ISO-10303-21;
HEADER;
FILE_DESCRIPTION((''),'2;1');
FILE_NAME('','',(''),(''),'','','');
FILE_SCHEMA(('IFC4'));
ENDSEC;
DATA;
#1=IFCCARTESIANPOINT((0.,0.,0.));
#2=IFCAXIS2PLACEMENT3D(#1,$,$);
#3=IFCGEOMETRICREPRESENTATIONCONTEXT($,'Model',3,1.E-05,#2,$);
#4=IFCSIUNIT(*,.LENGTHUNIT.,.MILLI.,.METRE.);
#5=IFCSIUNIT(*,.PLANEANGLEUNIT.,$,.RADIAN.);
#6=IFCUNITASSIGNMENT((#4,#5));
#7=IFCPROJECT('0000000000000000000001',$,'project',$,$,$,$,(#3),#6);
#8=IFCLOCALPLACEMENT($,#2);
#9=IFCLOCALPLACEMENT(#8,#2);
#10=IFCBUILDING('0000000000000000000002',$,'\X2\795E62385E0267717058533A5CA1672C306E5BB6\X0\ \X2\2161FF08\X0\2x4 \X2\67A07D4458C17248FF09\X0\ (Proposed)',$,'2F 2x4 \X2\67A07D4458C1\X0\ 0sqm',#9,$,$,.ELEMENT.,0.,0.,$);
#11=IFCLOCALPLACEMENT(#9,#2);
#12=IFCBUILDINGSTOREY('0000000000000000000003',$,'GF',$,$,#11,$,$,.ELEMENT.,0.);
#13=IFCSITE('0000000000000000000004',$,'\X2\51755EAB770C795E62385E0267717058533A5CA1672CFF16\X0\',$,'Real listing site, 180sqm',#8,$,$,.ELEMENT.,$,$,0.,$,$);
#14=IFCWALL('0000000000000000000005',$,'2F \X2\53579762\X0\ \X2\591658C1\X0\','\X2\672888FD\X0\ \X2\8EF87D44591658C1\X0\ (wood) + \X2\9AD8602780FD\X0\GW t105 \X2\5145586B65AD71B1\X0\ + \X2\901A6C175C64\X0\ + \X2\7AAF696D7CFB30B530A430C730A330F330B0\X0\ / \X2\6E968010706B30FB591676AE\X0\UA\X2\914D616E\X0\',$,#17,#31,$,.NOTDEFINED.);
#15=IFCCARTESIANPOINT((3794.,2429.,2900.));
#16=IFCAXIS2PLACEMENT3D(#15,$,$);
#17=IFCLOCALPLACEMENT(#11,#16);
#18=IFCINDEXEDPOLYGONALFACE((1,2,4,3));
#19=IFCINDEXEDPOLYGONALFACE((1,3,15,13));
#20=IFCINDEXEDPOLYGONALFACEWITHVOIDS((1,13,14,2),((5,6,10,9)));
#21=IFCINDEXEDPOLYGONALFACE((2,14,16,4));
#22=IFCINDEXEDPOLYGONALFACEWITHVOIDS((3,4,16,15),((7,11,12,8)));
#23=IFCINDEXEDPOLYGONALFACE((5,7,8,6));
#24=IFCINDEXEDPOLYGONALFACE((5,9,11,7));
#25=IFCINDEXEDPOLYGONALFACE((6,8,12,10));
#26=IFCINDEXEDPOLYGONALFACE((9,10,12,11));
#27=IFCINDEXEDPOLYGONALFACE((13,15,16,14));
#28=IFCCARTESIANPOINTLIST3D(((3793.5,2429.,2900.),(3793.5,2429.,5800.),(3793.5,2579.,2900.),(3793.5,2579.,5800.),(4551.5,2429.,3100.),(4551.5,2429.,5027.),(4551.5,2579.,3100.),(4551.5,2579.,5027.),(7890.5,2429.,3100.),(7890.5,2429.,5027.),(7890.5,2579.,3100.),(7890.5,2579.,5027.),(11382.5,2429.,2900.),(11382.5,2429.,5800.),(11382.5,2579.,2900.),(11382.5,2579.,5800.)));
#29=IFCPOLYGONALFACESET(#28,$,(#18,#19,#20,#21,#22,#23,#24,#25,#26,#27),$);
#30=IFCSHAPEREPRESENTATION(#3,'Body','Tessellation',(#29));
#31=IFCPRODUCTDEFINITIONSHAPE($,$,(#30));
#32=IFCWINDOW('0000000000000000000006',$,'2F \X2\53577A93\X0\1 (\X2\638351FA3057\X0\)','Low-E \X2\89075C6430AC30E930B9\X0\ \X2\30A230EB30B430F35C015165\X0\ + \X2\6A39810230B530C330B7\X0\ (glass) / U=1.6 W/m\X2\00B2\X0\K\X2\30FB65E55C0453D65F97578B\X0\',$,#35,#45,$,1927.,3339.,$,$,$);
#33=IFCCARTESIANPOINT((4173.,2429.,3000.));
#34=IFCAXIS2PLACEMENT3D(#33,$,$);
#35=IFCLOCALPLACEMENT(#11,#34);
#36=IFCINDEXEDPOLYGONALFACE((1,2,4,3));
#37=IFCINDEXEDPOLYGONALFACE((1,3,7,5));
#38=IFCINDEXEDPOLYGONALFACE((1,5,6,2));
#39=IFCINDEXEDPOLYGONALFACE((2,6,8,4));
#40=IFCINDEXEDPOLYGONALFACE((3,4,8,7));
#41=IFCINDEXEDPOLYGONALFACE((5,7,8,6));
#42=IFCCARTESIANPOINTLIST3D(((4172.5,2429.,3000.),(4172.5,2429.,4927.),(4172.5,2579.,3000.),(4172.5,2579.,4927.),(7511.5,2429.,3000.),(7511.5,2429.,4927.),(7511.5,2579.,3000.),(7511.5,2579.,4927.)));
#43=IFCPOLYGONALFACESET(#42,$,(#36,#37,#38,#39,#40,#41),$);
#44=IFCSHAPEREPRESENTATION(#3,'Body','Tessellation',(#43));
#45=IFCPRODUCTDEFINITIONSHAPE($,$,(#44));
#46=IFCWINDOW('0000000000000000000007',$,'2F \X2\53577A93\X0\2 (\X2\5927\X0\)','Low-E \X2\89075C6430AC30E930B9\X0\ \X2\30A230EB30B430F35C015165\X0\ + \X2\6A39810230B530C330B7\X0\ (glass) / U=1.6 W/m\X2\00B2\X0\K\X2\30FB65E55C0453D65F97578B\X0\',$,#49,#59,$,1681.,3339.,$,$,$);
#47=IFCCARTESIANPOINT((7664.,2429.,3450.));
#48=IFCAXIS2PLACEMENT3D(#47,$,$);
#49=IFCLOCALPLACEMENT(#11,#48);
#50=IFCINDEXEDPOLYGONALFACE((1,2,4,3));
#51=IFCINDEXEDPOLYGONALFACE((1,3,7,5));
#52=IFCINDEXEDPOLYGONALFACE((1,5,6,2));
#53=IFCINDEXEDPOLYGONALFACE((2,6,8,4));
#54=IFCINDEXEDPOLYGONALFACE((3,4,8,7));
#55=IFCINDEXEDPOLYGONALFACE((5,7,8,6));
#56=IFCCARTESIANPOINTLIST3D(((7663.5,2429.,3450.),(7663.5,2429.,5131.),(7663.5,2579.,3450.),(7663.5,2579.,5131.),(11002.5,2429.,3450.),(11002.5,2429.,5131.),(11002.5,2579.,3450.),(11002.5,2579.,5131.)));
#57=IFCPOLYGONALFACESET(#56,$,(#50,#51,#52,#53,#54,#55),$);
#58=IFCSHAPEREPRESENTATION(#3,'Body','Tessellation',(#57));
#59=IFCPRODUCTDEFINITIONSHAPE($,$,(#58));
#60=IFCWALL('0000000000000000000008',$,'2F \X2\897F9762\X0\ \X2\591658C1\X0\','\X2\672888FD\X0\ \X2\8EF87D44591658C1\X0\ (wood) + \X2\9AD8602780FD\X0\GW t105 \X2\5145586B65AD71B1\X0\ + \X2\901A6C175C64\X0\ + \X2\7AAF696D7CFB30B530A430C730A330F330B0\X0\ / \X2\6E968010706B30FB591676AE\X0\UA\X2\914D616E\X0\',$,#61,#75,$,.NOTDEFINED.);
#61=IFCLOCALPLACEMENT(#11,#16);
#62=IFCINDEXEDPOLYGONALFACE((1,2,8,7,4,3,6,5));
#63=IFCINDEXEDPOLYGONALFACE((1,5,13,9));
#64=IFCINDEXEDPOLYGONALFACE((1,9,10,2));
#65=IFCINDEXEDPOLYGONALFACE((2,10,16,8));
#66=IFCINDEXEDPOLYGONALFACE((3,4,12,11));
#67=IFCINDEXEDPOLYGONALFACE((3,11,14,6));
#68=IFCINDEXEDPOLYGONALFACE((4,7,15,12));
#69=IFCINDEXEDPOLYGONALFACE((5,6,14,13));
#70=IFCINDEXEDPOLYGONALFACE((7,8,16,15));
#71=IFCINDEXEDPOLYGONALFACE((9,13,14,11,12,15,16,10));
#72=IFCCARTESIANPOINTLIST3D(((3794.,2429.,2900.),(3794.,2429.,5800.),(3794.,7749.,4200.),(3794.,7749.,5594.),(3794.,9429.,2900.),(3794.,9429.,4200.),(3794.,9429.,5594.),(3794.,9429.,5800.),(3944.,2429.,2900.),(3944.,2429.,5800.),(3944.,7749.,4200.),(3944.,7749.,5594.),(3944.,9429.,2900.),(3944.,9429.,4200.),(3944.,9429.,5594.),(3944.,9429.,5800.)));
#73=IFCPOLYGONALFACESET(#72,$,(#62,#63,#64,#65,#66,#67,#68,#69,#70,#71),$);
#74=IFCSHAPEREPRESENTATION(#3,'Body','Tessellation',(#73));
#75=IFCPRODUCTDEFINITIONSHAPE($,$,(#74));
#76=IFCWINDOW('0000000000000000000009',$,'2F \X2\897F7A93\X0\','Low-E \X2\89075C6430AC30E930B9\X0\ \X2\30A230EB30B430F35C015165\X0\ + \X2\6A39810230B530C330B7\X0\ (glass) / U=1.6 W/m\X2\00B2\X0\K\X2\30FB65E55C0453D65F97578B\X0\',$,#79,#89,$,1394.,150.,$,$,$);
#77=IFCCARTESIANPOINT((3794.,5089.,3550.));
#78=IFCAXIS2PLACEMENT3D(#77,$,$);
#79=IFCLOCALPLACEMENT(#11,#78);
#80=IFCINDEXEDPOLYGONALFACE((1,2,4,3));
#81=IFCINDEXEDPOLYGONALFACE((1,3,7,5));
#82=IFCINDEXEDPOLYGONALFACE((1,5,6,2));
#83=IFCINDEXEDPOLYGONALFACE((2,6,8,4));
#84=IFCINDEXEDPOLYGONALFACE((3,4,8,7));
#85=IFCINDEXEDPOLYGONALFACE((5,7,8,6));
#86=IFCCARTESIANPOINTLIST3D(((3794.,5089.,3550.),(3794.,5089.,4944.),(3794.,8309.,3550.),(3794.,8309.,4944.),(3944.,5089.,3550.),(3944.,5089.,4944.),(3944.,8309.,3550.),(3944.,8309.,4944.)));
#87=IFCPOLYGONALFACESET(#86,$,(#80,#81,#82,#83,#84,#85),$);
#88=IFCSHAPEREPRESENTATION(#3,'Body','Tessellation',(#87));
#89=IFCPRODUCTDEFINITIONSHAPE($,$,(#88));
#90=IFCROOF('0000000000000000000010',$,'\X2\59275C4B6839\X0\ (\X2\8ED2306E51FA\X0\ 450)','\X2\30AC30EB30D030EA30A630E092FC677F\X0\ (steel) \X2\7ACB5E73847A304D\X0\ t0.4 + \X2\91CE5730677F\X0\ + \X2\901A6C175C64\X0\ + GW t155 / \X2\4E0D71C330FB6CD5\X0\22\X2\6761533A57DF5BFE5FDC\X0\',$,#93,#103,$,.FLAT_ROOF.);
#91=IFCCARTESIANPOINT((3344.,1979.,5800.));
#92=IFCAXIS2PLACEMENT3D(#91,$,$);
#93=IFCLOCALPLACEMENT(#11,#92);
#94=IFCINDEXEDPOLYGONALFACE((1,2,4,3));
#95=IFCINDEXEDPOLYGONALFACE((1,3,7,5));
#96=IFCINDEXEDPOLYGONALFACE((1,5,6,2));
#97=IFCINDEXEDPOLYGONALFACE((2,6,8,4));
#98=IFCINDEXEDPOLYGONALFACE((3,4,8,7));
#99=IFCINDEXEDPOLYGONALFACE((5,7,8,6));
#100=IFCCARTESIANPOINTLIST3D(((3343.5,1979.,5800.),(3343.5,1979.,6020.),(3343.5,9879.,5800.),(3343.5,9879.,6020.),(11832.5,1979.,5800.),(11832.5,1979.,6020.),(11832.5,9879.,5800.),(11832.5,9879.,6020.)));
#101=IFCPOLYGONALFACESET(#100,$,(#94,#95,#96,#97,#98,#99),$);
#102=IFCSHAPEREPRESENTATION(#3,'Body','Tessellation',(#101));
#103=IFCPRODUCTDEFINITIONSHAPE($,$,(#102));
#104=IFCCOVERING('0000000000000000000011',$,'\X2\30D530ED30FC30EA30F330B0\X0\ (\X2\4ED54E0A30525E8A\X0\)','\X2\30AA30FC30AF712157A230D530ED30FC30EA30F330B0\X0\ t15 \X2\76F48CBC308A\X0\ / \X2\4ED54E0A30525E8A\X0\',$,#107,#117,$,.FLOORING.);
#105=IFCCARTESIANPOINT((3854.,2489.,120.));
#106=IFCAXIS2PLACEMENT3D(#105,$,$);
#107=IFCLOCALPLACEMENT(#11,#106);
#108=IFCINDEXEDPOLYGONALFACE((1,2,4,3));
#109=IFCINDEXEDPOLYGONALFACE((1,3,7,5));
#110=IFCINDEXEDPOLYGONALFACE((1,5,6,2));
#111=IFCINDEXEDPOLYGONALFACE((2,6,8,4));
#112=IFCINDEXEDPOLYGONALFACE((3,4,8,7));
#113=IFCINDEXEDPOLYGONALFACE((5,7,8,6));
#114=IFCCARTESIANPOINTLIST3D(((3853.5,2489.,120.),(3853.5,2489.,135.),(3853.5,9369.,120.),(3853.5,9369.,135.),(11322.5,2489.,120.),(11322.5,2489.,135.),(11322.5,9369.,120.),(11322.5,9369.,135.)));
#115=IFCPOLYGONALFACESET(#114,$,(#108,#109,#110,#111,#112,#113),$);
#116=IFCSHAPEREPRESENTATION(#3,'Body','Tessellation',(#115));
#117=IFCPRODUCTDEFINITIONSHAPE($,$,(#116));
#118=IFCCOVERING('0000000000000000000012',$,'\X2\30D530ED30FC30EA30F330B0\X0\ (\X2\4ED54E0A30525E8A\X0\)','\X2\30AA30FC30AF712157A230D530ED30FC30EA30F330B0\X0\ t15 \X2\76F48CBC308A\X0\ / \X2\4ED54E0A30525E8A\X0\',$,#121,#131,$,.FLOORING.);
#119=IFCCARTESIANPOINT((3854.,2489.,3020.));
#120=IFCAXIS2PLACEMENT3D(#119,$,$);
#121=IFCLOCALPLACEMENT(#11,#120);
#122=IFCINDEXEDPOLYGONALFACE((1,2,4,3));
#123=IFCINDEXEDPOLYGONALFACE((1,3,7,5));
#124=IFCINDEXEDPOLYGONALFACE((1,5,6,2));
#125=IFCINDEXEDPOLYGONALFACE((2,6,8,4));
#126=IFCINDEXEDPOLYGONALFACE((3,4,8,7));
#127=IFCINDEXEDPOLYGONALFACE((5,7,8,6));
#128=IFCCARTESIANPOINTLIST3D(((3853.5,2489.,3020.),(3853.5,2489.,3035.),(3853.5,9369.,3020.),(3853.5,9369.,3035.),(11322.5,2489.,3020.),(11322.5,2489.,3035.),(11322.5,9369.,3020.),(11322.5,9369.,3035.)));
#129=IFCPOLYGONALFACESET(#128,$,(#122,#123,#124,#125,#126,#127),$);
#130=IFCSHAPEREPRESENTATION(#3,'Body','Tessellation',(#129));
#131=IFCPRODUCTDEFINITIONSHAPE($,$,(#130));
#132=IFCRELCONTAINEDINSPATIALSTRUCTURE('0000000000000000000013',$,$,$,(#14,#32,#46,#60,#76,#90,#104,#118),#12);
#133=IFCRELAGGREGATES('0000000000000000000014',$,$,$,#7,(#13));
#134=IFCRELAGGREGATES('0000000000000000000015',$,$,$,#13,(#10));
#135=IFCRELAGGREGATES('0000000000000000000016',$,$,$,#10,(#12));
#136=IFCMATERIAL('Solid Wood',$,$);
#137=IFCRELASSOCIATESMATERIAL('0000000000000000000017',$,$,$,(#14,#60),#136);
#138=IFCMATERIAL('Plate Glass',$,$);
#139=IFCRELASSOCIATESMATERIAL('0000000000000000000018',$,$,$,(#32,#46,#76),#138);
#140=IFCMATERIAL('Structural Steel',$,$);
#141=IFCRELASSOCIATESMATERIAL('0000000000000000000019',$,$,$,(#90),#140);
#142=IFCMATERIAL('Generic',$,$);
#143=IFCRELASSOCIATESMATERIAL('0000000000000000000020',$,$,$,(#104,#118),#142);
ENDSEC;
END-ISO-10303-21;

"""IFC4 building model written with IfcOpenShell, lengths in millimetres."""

from ifc_helpers import new_model, si_unit, frame, frame_2d, origin, place, context, project, spatial, rectangle, extrude, material, element, fill, save


model = new_model("IFC4")

# Units and contexts
model_context = context("Model", 3, precision=1e-05, world=origin())
ifc_project = project(units=[si_unit("LENGTHUNIT", "METRE", prefix="MILLI"), si_unit("PLANEANGLEUNIT", "RADIAN")], contexts=[model_context])

# Site, building, storey
site_placement = place(None, origin())
site = spatial("IfcSite", under=ifc_project, at=site_placement, Name="兵庫県神戸市東灘区岡本６", ObjectType="Real listing site, 180sqm", CompositionType="ELEMENT", RefElevation=0.0)
building_placement = place(site_placement, origin())
building = spatial("IfcBuilding", under=site, at=building_placement, Name="神戸市東灘区岡本の家 Ⅱ（2x4 枠組壁版） (Proposed)", ObjectType="2F 2x4 枠組壁 0sqm", CompositionType="ELEMENT", ElevationOfRefHeight=0.0, ElevationOfTerrain=0.0)
storey_placement = place(building_placement, origin())
storey = spatial("IfcBuildingStorey", under=building, at=storey_placement, Name="GF", CompositionType="ELEMENT", Elevation=0.0)

# Shared definitions
ifc_material_1 = material(Name="Solid Wood")

# Shared definitions
ifc_material_2 = material(Name="Plate Glass")

# Wall, openings, windows
wall_1_placement = place(storey_placement, frame((3794.0, 2429.0, 2900.0)))
wall_1 = element("IfcWall", 1, at=wall_1_placement, inside=storey, material=ifc_material_1, Name="2F 南面 外壁", Description="木製 軸組外壁 (wood) + 高性能GW t105 充填断熱 + 通気層 + 窯業系サイディング / 準耐火・外皮UA配慮", PredefinedType="NOTDEFINED", context=model_context, shape_type="SweptSolid", body=[
    extrude(rectangle(XDim=7589.0, YDim=150.0, at=frame_2d((3794.0, 75.0))), frame((3794.0, 2429.0, 2900.0)), (0.0, 0.0, 1.0), 2900.0),
])
opening_1_placement = place(storey_placement, frame((4173.0, 2429.0, 3000.0)))
opening_1 = element("IfcOpeningElement", 2, at=opening_1_placement, cuts=wall_1, PredefinedType="NOTDEFINED", context=model_context, shape_type="SweptSolid", body=[
    extrude(rectangle(XDim=3339.0, YDim=150.0, at=frame_2d((1669.0, 75.0))), frame((4173.0, 2429.0, 3000.0)), (0.0, 0.0, 1.0), 1927.0),
])
opening_2_placement = place(storey_placement, frame((7664.0, 2429.0, 3450.0)))
opening_2 = element("IfcOpeningElement", 3, at=opening_2_placement, cuts=wall_1, PredefinedType="NOTDEFINED", context=model_context, shape_type="SweptSolid", body=[
    extrude(rectangle(XDim=3339.0, YDim=150.0, at=frame_2d((1669.0, 75.0))), frame((7664.0, 2429.0, 3450.0)), (0.0, 0.0, 1.0), 1681.0),
])
window_1_placement = place(storey_placement, frame((4173.0, 2429.0, 3000.0)))
window_1 = element("IfcWindow", 4, at=window_1_placement, inside=storey, material=ifc_material_2, Name="2F 南窓1 (掃出し)", Description="Low-E 複層ガラス アルゴン封入 + 樹脂サッシ (glass) / U=1.6 W/m²K・日射取得型", OverallHeight=1927.0, OverallWidth=3339.0, context=model_context, shape_type="SweptSolid", body=[
    extrude(rectangle(XDim=3339.0, YDim=150.0, at=frame_2d((1669.0, 75.0))), frame((4173.0, 2429.0, 3000.0)), (0.0, 0.0, 1.0), 1927.0),
])
fill(opening_1, window_1)
window_2_placement = place(storey_placement, frame((7664.0, 2429.0, 3450.0)))
window_2 = element("IfcWindow", 5, at=window_2_placement, inside=storey, material=ifc_material_2, Name="2F 南窓2 (大)", Description="Low-E 複層ガラス アルゴン封入 + 樹脂サッシ (glass) / U=1.6 W/m²K・日射取得型", OverallHeight=1681.0, OverallWidth=3339.0, context=model_context, shape_type="SweptSolid", body=[
    extrude(rectangle(XDim=3339.0, YDim=150.0, at=frame_2d((1669.0, 75.0))), frame((7664.0, 2429.0, 3450.0)), (0.0, 0.0, 1.0), 1681.0),
])
fill(opening_2, window_2)

# Wall, opening, window
wall_2_placement = place(storey_placement, frame((3794.0, 2429.0, 2900.0)))
wall_2 = element("IfcWall", 6, at=wall_2_placement, inside=storey, material=ifc_material_1, Name="2F 西面 外壁", Description="木製 軸組外壁 (wood) + 高性能GW t105 充填断熱 + 通気層 + 窯業系サイディング / 準耐火・外皮UA配慮", PredefinedType="NOTDEFINED", context=model_context, shape_type="SweptSolid", body=[
    extrude(rectangle(XDim=150.0, YDim=7000.0, at=frame_2d((75.0, 3500.0))), frame((3794.0, 2429.0, 2900.0)), (0.0, 0.0, 1.0), 2900.0),
])
opening_3_placement = place(storey_placement, frame((3794.0, 5089.0, 3550.0)))
opening_3 = element("IfcOpeningElement", 7, at=opening_3_placement, cuts=wall_2, PredefinedType="NOTDEFINED", context=model_context, shape_type="SweptSolid", body=[
    extrude(rectangle(XDim=150.0, YDim=3220.0, at=frame_2d((75.0, 1610.0))), frame((3794.0, 5089.0, 3550.0)), (0.0, 0.0, 1.0), 1394.0),
])
window_3_placement = place(storey_placement, frame((3794.0, 5089.0, 3550.0)))
window_3 = element("IfcWindow", 8, at=window_3_placement, inside=storey, material=ifc_material_2, Name="2F 西窓", Description="Low-E 複層ガラス アルゴン封入 + 樹脂サッシ (glass) / U=1.6 W/m²K・日射取得型", OverallHeight=1394.0, OverallWidth=150.0, context=model_context, shape_type="SweptSolid", body=[
    extrude(rectangle(XDim=150.0, YDim=3220.0, at=frame_2d((75.0, 1610.0))), frame((3794.0, 5089.0, 3550.0)), (0.0, 0.0, 1.0), 1394.0),
])
fill(opening_3, window_3)

# Roof
ifc_material_3 = material(Name="Structural Steel")
roof_placement = place(storey_placement, frame((3344.0, 1979.0, 5800.0)))
element("IfcRoof", 9, at=roof_placement, inside=storey, material=ifc_material_3, Name="大屋根 (軒の出 450)", Description="ガルバリウム鋼板 (steel) 立平葺き t0.4 + 野地板 + 通気層 + GW t155 / 不燃・法22条区域対応", PredefinedType="FLAT_ROOF", context=model_context, shape_type="SweptSolid", body=[
    extrude(rectangle(XDim=8489.0, YDim=7900.0, at=frame_2d((4244.0, 3950.0))), frame((3344.0, 1979.0, 5800.0)), (0.0, 0.0, 1.0), 220.0),
])

# Coverings
ifc_material_4 = material(Name="Generic")
covering_1_placement = place(storey_placement, frame((3854.0, 2489.0, 120.0)))
element("IfcCovering", 10, at=covering_1_placement, inside=storey, material=ifc_material_4, Name="フローリング (仕上げ床)", Description="オーク無垢フローリング t15 直貼り / 仕上げ床", PredefinedType="FLOORING", context=model_context, shape_type="SweptSolid", body=[
    extrude(rectangle(XDim=7469.0, YDim=6880.0, at=frame_2d((3734.0, 3440.0))), frame((3854.0, 2489.0, 120.0)), (0.0, 0.0, 1.0), 15.0),
])
covering_2_placement = place(storey_placement, frame((3854.0, 2489.0, 3020.0)))
element("IfcCovering", 11, at=covering_2_placement, inside=storey, material=ifc_material_4, Name="フローリング (仕上げ床)", Description="オーク無垢フローリング t15 直貼り / 仕上げ床", PredefinedType="FLOORING", context=model_context, shape_type="SweptSolid", body=[
    extrude(rectangle(XDim=7469.0, YDim=6880.0, at=frame_2d((3734.0, 3440.0))), frame((3854.0, 2489.0, 3020.0)), (0.0, 0.0, 1.0), 15.0),
])

save(model, "model.ifc")
